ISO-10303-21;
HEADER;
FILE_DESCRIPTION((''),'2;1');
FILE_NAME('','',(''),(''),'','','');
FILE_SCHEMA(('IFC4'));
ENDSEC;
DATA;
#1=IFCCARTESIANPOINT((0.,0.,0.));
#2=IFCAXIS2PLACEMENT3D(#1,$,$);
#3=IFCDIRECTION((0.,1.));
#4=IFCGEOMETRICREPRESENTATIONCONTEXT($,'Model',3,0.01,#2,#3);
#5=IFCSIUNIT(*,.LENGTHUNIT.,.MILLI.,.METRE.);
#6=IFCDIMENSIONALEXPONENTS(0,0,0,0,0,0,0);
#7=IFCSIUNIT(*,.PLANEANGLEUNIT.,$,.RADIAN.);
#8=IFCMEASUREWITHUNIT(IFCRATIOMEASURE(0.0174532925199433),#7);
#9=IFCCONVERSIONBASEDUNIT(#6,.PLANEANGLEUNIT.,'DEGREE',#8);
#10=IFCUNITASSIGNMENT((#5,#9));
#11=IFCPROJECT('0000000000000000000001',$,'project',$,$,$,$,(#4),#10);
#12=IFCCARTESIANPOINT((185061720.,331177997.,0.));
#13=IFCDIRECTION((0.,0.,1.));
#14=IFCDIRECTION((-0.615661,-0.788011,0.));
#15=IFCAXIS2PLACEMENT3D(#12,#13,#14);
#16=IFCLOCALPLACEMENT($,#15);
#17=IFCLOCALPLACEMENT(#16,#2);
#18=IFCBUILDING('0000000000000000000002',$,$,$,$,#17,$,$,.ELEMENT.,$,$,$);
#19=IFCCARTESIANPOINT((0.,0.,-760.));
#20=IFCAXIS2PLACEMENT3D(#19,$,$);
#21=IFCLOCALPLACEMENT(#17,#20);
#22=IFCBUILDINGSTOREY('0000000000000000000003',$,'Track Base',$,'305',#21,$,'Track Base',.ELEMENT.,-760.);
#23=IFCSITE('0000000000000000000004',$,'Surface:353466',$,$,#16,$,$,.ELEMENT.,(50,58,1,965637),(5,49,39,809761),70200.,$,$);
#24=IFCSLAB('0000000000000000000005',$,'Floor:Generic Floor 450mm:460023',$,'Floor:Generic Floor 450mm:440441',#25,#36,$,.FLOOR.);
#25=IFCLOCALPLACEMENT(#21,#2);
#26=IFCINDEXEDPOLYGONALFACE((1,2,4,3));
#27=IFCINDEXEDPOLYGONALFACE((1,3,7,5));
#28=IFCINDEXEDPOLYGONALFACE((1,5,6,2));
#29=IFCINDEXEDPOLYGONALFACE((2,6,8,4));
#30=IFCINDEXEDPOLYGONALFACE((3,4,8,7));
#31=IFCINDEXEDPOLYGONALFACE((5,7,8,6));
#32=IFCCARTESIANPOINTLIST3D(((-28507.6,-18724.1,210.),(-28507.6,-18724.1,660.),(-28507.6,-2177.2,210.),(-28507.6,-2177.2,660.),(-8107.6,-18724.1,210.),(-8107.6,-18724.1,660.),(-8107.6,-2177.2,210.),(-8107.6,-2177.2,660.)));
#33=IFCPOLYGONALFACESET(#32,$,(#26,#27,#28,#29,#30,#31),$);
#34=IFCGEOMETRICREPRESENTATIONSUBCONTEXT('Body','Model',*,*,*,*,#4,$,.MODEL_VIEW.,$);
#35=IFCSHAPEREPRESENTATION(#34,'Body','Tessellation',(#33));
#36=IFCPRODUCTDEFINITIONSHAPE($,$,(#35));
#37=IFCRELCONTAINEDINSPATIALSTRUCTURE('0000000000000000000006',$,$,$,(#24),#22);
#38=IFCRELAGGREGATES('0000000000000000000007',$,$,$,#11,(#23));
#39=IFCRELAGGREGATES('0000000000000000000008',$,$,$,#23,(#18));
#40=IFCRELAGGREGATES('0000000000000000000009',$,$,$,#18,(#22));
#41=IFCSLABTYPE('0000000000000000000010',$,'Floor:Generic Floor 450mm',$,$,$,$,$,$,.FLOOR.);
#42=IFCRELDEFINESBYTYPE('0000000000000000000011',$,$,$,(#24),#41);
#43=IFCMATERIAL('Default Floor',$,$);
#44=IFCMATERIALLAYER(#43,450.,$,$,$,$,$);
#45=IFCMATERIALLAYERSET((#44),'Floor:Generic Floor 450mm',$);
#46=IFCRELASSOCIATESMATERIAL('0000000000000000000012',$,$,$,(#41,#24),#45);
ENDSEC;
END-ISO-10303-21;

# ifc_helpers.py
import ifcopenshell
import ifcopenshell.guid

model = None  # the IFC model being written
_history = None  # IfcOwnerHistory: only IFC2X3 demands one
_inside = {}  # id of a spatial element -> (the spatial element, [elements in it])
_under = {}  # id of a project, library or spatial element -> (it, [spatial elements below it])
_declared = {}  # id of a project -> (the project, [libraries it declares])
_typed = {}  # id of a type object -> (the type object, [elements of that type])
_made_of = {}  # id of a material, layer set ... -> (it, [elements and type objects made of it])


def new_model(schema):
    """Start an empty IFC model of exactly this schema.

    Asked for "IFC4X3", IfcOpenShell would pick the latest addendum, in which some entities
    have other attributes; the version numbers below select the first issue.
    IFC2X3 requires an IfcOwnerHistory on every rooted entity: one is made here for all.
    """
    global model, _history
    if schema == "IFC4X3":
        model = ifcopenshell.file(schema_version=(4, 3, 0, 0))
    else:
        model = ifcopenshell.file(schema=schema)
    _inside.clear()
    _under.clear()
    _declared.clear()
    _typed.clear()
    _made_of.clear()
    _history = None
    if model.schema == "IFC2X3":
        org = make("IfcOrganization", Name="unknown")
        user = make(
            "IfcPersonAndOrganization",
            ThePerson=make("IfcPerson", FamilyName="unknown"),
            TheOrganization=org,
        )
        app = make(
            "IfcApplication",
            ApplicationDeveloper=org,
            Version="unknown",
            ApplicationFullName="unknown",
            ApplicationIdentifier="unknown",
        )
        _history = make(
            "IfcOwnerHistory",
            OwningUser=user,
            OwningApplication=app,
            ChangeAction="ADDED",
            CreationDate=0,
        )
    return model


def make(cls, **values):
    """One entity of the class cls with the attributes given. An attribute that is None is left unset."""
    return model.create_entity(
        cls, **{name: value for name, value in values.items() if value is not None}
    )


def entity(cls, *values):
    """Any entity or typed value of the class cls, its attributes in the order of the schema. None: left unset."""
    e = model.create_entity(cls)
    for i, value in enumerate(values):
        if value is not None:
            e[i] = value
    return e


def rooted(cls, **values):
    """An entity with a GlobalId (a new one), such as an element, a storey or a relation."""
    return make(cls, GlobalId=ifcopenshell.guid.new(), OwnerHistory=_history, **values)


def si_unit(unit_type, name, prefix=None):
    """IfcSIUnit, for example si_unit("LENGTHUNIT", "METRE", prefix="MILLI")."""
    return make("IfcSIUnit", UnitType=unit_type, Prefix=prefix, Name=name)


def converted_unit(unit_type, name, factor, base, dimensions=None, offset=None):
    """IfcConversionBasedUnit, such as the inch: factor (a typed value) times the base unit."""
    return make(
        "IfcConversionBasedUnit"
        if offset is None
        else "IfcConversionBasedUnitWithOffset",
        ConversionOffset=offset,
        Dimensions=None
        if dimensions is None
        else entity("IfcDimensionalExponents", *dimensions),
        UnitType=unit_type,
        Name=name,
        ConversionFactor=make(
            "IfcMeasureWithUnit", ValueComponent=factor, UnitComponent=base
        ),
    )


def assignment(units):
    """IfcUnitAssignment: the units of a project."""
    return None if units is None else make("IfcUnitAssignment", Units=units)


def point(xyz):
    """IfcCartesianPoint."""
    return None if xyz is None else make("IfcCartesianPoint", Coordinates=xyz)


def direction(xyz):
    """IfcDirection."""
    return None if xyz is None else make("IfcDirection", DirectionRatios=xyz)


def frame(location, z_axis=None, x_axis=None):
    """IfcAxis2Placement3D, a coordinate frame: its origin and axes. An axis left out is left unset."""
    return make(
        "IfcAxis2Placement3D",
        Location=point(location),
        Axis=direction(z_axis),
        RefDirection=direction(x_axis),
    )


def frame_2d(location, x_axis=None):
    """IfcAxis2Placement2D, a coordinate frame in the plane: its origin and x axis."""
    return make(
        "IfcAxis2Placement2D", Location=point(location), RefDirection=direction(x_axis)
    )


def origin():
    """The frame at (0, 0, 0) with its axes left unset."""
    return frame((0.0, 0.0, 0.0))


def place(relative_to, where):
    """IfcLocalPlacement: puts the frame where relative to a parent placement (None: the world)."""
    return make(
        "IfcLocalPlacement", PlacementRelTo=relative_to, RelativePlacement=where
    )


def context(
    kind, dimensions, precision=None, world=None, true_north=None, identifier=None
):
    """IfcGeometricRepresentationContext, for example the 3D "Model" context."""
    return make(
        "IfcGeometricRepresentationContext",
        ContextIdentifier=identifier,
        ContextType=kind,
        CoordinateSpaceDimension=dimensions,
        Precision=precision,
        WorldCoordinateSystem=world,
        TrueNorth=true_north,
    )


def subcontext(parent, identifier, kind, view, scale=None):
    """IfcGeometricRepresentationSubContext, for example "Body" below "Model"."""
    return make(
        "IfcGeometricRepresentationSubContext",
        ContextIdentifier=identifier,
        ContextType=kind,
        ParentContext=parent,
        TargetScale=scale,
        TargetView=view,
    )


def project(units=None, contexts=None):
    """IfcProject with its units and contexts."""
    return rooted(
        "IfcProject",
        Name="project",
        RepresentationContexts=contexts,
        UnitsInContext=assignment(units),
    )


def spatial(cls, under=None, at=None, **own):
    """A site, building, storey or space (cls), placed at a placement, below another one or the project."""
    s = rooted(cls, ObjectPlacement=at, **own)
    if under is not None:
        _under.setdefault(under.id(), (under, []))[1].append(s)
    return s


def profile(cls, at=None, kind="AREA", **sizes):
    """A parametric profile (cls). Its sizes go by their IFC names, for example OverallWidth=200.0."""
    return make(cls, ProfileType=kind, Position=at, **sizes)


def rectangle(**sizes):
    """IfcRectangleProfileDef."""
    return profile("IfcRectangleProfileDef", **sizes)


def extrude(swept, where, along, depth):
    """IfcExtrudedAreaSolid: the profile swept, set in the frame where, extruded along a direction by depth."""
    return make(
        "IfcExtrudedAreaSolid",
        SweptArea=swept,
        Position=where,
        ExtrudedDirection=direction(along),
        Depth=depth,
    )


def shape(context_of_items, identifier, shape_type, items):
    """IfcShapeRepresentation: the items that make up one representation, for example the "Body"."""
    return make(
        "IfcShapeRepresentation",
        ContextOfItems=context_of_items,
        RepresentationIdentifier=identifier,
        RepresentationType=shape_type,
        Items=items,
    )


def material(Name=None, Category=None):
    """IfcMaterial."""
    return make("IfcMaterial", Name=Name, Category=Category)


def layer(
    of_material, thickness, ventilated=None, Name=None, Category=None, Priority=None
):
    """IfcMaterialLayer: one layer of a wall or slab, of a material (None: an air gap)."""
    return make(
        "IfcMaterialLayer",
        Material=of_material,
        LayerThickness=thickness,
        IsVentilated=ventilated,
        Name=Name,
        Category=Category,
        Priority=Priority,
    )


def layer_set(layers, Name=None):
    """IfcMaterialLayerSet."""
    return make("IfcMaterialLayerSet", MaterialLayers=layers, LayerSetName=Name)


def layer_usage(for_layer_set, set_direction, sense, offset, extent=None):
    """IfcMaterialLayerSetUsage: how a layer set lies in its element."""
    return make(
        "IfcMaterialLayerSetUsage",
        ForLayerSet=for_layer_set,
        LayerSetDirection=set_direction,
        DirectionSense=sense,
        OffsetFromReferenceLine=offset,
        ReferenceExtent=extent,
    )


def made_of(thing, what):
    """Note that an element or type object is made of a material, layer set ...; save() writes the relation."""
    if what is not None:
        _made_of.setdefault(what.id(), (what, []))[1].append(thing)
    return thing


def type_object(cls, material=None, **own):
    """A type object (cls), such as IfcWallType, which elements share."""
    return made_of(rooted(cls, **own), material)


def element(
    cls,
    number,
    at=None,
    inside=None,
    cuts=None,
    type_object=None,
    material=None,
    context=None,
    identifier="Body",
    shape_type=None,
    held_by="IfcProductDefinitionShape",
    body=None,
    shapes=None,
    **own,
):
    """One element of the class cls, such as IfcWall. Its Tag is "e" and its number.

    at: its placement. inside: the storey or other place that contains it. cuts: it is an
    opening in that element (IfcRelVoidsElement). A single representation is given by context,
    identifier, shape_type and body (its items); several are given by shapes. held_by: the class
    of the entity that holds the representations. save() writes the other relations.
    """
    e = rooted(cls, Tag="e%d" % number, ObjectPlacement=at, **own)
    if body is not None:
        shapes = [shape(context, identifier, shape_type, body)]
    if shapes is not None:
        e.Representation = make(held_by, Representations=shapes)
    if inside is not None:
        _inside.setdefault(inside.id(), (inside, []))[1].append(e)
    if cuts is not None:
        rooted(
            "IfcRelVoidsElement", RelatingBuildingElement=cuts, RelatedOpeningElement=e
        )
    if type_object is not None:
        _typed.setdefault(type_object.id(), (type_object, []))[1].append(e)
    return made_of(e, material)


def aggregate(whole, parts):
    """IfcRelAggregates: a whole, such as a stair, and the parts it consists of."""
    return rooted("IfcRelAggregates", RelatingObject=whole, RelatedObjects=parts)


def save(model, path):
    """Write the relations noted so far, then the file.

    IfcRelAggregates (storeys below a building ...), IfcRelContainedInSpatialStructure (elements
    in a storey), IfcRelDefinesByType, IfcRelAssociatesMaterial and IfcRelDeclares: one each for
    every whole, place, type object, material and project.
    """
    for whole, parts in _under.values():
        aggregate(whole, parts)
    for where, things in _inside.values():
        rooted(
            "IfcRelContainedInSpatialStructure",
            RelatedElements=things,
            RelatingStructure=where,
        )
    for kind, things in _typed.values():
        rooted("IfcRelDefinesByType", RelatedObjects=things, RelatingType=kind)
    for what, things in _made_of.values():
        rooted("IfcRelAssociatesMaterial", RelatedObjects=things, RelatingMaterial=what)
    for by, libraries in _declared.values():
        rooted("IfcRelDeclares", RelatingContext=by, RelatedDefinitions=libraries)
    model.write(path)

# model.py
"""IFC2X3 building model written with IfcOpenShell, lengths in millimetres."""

from ifc_helpers import new_model, entity, si_unit, converted_unit, direction, frame, frame_2d, origin, place, context, subcontext, project, spatial, rectangle, extrude, material, layer, layer_set, layer_usage, type_object, element, save


model = new_model("IFC2X3")

# Units and contexts
model_context = context("Model", 3, precision=0.01, world=origin(), true_north=direction((0.0, 1.0)))
body_context = subcontext(model_context, "Body", "Model", "MODEL_VIEW")
ifc_project = project(units=[si_unit("LENGTHUNIT", "METRE", prefix="MILLI"), converted_unit("PLANEANGLEUNIT", "DEGREE", entity("IfcRatioMeasure", 0.0174532925199433), si_unit("PLANEANGLEUNIT", "RADIAN"), dimensions=[0, 0, 0, 0, 0, 0, 0])], contexts=[model_context])

# Site, building, storey
site_placement = place(None, frame((185061720.0, 331177997.0, 0.0), z_axis=(0.0, 0.0, 1.0), x_axis=(-0.615661, -0.788011, 0.0)))
site = spatial("IfcSite", under=ifc_project, at=site_placement, Name="Surface:353466", CompositionType="ELEMENT", RefLatitude=(50, 58, 1, 965637), RefLongitude=(5, 49, 39, 809761), RefElevation=70200.0)
building_placement = place(site_placement, origin())
building = spatial("IfcBuilding", under=site, at=building_placement, CompositionType="ELEMENT")
storey_placement = place(building_placement, frame((0.0, 0.0, -760.0)))
storey = spatial("IfcBuildingStorey", under=building, at=storey_placement, Name="Track Base", ObjectType="305", LongName="Track Base", CompositionType="ELEMENT", Elevation=-760.0)

# Shared definitions
ifc_material = material(Name="Default Floor")
ifc_layer = layer(ifc_material, 450.0)
ifc_layer_set = layer_set([ifc_layer], Name="Floor:Generic Floor 450mm")
slab_type = type_object("IfcSlabType", Name="Floor:Generic Floor 450mm", PredefinedType="FLOOR", material=ifc_layer_set)

# Slab
ifc_layer_usage_1 = layer_usage(ifc_layer_set, "AXIS3", "POSITIVE", 0.0)
slab_1_placement = place(storey_placement, origin())
element("IfcSlab", 1, at=slab_1_placement, inside=storey, type_object=slab_type, material=ifc_layer_usage_1, Name="Floor:Generic Floor 450mm:460023", ObjectType="Floor:Generic Floor 450mm:440441", PredefinedType="FLOOR", context=body_context, shape_type="SweptSolid", body=[
    extrude(rectangle(XDim=16546.9, YDim=20400.0, at=frame_2d((0.0, 0.0), x_axis=(1.0, 0.0))), frame((-18307.6, -10450.7, 660.0), z_axis=(0.0, 0.0, -1.0), x_axis=(0.0, 1.0, 0.0)), (0.0, 0.0, 1.0), 450.0),
])

save(model, "model.ifc")
